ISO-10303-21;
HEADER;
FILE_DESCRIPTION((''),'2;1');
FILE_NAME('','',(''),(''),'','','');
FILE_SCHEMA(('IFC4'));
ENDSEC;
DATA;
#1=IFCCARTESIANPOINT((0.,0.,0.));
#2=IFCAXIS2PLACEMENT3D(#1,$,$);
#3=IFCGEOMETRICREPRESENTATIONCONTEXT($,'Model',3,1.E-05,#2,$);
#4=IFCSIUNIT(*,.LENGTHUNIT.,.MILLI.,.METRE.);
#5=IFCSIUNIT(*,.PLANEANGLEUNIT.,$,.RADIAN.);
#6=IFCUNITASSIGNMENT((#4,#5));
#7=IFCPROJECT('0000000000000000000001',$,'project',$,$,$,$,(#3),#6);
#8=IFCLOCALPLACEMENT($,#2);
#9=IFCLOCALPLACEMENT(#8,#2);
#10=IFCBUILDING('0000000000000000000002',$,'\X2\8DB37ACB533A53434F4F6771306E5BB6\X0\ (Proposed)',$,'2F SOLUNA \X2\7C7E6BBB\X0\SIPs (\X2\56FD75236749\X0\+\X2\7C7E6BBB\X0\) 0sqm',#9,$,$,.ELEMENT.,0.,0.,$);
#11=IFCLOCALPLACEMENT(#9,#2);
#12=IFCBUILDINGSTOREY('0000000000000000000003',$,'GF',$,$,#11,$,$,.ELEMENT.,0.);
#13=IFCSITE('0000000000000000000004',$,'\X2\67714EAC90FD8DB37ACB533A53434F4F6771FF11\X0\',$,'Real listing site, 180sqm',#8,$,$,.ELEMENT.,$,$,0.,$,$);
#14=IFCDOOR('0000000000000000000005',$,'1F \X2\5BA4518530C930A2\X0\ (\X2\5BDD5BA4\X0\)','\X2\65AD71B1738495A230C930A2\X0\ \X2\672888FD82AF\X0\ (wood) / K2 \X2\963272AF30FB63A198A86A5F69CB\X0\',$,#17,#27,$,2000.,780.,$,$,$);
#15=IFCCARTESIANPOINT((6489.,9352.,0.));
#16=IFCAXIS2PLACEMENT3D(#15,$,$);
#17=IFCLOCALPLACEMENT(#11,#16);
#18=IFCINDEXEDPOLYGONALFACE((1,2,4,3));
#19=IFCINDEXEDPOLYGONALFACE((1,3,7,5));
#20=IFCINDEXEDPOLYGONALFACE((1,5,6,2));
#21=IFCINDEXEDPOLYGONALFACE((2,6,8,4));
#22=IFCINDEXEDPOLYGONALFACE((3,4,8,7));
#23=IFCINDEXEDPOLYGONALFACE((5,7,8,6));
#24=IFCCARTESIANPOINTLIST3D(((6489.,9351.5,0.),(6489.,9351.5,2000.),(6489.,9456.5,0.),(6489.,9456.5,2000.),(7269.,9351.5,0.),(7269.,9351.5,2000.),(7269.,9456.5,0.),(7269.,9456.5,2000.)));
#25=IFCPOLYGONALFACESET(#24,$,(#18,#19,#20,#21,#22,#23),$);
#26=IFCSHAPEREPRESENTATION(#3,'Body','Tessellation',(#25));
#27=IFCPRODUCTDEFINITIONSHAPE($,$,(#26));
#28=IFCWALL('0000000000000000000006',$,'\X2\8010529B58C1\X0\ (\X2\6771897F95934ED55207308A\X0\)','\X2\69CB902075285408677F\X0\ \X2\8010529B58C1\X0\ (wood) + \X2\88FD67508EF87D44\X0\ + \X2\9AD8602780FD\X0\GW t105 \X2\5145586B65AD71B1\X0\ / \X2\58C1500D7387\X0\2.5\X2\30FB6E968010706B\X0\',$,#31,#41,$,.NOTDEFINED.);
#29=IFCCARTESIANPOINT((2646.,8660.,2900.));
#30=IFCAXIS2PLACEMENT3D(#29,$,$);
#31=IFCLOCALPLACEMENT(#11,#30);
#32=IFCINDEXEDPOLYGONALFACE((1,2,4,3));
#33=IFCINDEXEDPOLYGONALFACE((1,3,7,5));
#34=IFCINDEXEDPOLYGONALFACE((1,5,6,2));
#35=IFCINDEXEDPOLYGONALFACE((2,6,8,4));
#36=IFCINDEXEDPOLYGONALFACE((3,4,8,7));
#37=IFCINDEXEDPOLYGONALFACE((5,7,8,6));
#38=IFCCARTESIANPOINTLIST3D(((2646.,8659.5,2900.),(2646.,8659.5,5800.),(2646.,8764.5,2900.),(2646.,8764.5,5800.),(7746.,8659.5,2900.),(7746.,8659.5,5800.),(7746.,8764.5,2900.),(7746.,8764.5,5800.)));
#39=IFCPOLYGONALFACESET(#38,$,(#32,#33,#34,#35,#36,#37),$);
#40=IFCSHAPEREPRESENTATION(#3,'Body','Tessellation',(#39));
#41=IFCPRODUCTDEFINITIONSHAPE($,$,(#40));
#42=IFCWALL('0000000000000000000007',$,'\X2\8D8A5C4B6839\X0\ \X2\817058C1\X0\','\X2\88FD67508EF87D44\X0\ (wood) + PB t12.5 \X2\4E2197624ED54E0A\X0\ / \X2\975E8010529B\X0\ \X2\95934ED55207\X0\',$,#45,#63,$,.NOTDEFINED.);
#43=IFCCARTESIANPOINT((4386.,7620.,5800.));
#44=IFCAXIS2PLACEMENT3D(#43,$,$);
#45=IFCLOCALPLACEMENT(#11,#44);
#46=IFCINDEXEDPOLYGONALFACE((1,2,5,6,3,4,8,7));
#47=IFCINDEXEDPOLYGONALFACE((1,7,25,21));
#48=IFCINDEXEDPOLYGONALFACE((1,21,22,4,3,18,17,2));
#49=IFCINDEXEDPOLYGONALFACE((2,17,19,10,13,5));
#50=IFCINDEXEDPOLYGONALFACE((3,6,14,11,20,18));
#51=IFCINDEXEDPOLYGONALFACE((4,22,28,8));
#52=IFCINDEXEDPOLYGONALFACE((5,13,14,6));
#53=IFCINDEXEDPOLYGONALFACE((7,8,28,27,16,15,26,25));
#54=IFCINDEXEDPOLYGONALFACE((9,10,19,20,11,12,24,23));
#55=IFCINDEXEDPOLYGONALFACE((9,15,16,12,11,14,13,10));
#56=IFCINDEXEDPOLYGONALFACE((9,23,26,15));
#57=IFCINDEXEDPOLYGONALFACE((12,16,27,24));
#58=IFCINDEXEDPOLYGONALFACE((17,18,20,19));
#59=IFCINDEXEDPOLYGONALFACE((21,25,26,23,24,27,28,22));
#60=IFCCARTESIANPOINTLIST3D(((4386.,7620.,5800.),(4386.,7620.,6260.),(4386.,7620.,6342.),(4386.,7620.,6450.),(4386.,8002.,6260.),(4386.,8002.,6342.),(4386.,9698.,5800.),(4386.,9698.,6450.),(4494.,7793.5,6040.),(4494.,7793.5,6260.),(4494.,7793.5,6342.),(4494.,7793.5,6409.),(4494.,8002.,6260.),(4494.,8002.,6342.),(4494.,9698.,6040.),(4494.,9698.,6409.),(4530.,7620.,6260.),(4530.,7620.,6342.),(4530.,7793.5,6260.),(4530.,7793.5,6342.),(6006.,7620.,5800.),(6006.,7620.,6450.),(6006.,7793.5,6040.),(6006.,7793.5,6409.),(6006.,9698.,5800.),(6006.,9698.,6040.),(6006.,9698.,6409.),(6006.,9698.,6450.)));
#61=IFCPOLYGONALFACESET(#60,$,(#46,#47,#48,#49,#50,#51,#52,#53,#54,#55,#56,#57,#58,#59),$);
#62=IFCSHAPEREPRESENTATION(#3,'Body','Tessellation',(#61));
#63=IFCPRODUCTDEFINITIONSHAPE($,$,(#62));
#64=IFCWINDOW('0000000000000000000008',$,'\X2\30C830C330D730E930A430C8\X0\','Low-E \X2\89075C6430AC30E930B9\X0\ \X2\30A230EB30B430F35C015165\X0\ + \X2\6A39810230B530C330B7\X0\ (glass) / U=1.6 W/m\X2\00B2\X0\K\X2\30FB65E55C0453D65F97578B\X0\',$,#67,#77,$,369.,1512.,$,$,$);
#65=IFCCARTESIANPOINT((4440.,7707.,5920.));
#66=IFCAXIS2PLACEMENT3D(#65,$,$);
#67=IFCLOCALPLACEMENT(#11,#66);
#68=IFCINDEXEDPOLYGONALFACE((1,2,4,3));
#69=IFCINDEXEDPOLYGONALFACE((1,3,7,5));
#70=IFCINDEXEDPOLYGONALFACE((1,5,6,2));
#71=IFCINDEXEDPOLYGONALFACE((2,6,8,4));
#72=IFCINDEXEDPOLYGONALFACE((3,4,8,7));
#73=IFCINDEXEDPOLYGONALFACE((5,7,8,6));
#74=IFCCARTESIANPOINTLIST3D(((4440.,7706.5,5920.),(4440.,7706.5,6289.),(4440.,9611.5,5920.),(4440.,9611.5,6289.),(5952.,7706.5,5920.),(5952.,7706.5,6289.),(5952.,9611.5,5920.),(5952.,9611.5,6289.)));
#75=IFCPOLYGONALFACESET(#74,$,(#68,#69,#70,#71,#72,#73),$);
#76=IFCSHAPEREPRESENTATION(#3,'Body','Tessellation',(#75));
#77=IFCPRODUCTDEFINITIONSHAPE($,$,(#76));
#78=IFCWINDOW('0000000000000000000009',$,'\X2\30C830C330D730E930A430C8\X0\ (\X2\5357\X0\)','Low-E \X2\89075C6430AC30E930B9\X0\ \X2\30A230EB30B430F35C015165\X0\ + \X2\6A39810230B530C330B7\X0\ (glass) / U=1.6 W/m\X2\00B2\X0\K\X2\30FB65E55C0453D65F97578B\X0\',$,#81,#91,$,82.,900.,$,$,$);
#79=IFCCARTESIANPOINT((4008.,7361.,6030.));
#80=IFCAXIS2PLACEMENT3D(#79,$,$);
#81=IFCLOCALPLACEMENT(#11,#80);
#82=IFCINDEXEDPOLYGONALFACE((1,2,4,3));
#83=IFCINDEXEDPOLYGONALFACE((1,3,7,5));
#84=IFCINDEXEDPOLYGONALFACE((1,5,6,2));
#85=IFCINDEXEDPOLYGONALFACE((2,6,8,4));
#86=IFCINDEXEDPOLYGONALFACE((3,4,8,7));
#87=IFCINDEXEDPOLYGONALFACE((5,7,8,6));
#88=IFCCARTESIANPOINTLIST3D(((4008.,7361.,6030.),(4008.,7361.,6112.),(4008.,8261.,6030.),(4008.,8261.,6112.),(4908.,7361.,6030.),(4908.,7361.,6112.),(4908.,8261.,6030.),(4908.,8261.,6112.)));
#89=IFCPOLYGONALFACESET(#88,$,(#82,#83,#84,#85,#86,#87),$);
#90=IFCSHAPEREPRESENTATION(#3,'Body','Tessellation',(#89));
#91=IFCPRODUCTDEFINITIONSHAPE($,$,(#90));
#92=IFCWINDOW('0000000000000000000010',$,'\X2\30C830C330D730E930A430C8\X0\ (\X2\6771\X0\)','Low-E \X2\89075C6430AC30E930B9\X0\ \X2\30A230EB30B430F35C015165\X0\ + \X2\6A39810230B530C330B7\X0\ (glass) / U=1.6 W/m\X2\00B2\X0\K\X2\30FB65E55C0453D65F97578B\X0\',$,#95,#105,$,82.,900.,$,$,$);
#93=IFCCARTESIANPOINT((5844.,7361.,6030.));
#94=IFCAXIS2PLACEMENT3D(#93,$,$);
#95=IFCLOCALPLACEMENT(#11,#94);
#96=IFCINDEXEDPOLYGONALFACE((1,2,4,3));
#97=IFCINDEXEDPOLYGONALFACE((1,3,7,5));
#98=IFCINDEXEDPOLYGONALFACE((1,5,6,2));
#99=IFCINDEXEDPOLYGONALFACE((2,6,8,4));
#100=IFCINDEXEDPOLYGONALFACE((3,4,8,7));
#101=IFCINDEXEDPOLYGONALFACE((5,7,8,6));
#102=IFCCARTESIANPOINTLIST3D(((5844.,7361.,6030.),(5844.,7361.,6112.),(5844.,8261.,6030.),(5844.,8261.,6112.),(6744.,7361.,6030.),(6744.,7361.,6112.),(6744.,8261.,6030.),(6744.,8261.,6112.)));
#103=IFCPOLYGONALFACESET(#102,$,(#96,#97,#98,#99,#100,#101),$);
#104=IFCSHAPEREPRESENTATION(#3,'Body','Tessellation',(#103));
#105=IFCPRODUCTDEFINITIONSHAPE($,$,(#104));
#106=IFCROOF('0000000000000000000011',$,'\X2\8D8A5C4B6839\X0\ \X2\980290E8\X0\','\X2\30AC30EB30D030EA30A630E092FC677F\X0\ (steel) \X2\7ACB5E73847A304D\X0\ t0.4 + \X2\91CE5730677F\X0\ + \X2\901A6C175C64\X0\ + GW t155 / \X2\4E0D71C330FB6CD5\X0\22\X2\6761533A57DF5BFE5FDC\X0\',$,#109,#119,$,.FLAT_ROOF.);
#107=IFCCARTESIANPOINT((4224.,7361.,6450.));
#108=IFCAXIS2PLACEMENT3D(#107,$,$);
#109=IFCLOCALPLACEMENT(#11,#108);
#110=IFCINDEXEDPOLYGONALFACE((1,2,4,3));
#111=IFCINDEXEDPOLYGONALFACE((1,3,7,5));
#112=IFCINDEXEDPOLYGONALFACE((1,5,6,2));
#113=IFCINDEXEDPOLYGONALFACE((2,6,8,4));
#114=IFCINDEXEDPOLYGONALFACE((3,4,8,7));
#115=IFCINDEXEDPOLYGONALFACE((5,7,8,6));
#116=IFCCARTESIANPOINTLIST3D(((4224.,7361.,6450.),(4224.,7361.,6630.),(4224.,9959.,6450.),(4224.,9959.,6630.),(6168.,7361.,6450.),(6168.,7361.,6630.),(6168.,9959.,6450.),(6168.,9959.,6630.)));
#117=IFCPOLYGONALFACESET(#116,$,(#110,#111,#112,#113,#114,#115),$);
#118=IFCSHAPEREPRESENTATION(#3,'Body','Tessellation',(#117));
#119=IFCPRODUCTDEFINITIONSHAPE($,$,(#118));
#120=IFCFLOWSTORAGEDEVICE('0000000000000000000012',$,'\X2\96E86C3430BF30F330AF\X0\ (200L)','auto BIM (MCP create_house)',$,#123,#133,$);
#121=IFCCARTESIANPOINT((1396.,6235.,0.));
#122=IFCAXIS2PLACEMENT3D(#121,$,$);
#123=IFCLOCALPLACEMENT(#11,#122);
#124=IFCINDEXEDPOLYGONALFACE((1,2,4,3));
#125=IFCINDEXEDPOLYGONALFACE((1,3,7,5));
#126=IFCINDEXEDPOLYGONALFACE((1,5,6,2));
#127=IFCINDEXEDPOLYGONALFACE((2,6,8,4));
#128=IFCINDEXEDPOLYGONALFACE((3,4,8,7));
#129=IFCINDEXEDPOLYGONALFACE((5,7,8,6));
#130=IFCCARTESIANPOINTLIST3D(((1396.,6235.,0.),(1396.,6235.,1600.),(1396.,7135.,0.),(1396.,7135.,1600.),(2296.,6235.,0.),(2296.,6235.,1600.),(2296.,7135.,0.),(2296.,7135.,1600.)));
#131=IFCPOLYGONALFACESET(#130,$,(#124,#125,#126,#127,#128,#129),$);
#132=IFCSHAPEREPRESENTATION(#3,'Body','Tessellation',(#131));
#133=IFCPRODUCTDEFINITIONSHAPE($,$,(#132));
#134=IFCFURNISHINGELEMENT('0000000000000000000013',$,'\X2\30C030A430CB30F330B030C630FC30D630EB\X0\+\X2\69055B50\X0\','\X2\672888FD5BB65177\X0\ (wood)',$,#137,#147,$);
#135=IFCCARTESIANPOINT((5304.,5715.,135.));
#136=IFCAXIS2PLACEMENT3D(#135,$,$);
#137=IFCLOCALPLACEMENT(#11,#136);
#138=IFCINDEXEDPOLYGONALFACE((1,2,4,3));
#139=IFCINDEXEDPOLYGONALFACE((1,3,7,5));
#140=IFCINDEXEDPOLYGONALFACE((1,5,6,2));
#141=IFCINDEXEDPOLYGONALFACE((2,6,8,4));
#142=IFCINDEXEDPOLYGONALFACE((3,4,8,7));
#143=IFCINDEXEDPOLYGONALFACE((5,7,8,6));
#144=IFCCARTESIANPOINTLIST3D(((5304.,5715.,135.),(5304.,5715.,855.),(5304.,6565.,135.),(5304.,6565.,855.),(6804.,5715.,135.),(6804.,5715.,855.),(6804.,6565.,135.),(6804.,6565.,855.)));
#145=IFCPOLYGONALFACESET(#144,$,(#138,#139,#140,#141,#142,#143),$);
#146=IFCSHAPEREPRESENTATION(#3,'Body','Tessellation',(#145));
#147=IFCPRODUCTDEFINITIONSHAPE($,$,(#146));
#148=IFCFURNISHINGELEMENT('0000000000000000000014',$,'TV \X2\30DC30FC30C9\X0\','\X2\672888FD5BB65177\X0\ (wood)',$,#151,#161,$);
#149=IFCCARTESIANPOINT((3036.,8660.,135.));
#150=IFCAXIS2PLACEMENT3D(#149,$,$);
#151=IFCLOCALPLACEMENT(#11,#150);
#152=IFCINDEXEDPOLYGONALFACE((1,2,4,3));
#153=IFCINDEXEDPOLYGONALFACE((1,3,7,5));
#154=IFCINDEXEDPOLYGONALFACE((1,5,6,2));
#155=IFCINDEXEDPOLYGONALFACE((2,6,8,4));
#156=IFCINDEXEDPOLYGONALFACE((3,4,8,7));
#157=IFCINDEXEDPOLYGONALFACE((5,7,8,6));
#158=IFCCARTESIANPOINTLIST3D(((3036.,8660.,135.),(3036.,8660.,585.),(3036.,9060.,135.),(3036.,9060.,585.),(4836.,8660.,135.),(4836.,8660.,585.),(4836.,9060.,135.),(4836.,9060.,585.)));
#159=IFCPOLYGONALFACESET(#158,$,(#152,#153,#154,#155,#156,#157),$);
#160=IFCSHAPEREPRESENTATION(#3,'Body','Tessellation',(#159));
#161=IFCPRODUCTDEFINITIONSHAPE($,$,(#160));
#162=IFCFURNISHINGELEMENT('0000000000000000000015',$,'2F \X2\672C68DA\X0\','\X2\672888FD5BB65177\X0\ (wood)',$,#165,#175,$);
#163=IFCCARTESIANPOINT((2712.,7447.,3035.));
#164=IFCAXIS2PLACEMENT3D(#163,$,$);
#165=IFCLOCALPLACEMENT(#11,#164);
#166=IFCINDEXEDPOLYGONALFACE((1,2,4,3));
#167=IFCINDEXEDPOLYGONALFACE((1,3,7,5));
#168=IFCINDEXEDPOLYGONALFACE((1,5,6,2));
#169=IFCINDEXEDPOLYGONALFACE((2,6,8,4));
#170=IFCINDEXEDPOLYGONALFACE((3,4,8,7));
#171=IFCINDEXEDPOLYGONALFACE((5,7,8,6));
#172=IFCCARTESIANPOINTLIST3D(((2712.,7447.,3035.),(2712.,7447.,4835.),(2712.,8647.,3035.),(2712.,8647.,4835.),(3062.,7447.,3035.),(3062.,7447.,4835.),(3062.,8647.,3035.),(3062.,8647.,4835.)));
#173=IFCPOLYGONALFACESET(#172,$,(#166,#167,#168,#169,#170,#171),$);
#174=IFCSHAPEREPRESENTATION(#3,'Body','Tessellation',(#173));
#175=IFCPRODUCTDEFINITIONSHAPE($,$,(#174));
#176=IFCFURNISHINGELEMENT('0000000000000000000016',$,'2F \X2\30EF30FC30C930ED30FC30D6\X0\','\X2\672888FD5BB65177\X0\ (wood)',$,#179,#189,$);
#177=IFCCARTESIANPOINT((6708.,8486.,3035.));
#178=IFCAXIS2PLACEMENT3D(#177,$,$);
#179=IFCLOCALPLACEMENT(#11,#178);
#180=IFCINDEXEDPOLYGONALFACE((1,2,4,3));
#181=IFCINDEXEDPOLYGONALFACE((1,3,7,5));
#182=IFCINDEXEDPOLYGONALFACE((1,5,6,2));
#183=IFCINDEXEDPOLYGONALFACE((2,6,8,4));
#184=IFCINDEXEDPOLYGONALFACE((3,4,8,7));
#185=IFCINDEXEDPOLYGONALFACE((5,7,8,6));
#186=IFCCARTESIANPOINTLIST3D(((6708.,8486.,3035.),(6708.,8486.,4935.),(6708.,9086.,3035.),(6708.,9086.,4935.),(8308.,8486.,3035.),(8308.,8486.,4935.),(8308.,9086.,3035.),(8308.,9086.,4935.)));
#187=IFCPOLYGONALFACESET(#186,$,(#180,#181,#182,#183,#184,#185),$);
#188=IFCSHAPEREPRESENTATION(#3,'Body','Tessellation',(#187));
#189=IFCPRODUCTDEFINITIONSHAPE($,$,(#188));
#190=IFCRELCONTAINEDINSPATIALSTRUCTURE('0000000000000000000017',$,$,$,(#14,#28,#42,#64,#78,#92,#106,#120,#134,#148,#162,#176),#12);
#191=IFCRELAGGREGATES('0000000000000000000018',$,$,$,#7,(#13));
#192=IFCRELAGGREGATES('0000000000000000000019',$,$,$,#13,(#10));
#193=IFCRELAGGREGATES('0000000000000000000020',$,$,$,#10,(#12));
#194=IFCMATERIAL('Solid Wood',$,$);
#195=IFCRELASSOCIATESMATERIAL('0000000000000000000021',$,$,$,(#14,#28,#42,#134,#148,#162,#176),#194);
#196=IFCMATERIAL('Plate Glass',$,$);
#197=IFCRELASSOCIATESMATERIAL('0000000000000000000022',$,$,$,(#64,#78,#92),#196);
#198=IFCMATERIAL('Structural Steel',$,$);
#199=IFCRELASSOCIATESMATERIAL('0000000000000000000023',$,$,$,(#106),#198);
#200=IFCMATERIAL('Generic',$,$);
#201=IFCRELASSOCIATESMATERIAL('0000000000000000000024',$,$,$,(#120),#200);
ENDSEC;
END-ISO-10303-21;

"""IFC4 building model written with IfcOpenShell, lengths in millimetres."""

from ifc_helpers import new_model, si_unit, frame, frame_2d, origin, place, context, project, spatial, rectangle, extrude, material, element, fill, save


model = new_model("IFC4")

# Units and contexts
model_context = context("Model", 3, precision=1e-05, world=origin())
ifc_project = project(units=[si_unit("LENGTHUNIT", "METRE", prefix="MILLI"), si_unit("PLANEANGLEUNIT", "RADIAN")], contexts=[model_context])

# Site, building, storey
site_placement = place(None, origin())
site = spatial("IfcSite", under=ifc_project, at=site_placement, Name="東京都足立区千住東１", ObjectType="Real listing site, 180sqm", CompositionType="ELEMENT", RefElevation=0.0)
building_placement = place(site_placement, origin())
building = spatial("IfcBuilding", under=site, at=building_placement, Name="足立区千住東の家 (Proposed)", ObjectType="2F SOLUNA 籾殻SIPs (国産杉+籾殻) 0sqm", CompositionType="ELEMENT", ElevationOfRefHeight=0.0, ElevationOfTerrain=0.0)
storey_placement = place(building_placement, origin())
storey = spatial("IfcBuildingStorey", under=building, at=storey_placement, Name="GF", CompositionType="ELEMENT", Elevation=0.0)

# Shared definitions
ifc_material_1 = material(Name="Solid Wood")

# Door
door_placement = place(storey_placement, frame((6489.0, 9352.0, 0.0)))
element("IfcDoor", 1, at=door_placement, inside=storey, material=ifc_material_1, Name="1F 室内ドア (寝室)", Description="断熱玄関ドア 木製芯 (wood) / K2 防犯・採風機構", OverallHeight=2000.0, OverallWidth=780.0, context=model_context, shape_type="SweptSolid", body=[
    extrude(rectangle(XDim=780.0, YDim=105.0, at=frame_2d((390.0, 52.0))), frame((6489.0, 9352.0, 0.0)), (0.0, 0.0, 1.0), 2000.0),
])

# Wall
wall_1_placement = place(storey_placement, frame((2646.0, 8660.0, 2900.0)))
element("IfcWall", 2, at=wall_1_placement, inside=storey, material=ifc_material_1, Name="耐力壁 (東西間仕切り)", Description="構造用合板 耐力壁 (wood) + 製材軸組 + 高性能GW t105 充填断熱 / 壁倍率2.5・準耐火", PredefinedType="NOTDEFINED", context=model_context, shape_type="SweptSolid", body=[
    extrude(rectangle(XDim=5100.0, YDim=105.0, at=frame_2d((2550.0, 52.0))), frame((2646.0, 8660.0, 2900.0)), (0.0, 0.0, 1.0), 2900.0),
])

# Wall, openings, windows
wall_2_placement = place(storey_placement, frame((4386.0, 7620.0, 5800.0)))
wall_2 = element("IfcWall", 3, at=wall_2_placement, inside=storey, material=ifc_material_1, Name="越屋根 腰壁", Description="製材軸組 (wood) + PB t12.5 両面仕上 / 非耐力 間仕切", PredefinedType="NOTDEFINED", context=model_context, shape_type="SweptSolid", body=[
    extrude(rectangle(XDim=1620.0, YDim=2078.0, at=frame_2d((810.0, 1039.0))), frame((4386.0, 7620.0, 5800.0)), (0.0, 0.0, 1.0), 650.0),
])
opening_1_placement = place(storey_placement, frame((4440.0, 7707.0, 5920.0)))
opening_1 = element("IfcOpeningElement", 4, at=opening_1_placement, cuts=wall_2, PredefinedType="NOTDEFINED", context=model_context, shape_type="SweptSolid", body=[
    extrude(rectangle(XDim=1512.0, YDim=1905.0, at=frame_2d((756.0, 952.0))), frame((4440.0, 7707.0, 5920.0)), (0.0, 0.0, 1.0), 369.0),
])
opening_2_placement = place(storey_placement, frame((4008.0, 7361.0, 6030.0)))
opening_2 = element("IfcOpeningElement", 5, at=opening_2_placement, cuts=wall_2, PredefinedType="NOTDEFINED", context=model_context, shape_type="SweptSolid", body=[
    extrude(rectangle(XDim=900.0, YDim=900.0, at=frame_2d((450.0, 450.0))), frame((4008.0, 7361.0, 6030.0)), (0.0, 0.0, 1.0), 82.0),
])
opening_3_placement = place(storey_placement, frame((5844.0, 7361.0, 6030.0)))
opening_3 = element("IfcOpeningElement", 6, at=opening_3_placement, cuts=wall_2, PredefinedType="NOTDEFINED", context=model_context, shape_type="SweptSolid", body=[
    extrude(rectangle(XDim=900.0, YDim=900.0, at=frame_2d((450.0, 450.0))), frame((5844.0, 7361.0, 6030.0)), (0.0, 0.0, 1.0), 82.0),
])
ifc_material_2 = material(Name="Plate Glass")
window_1_placement = place(storey_placement, frame((4440.0, 7707.0, 5920.0)))
window_1 = element("IfcWindow", 7, at=window_1_placement, inside=storey, material=ifc_material_2, Name="トップライト", Description="Low-E 複層ガラス アルゴン封入 + 樹脂サッシ (glass) / U=1.6 W/m²K・日射取得型", OverallHeight=369.0, OverallWidth=1512.0, context=model_context, shape_type="SweptSolid", body=[
    extrude(rectangle(XDim=1512.0, YDim=1905.0, at=frame_2d((756.0, 952.0))), frame((4440.0, 7707.0, 5920.0)), (0.0, 0.0, 1.0), 369.0),
])
fill(opening_1, window_1)
window_2_placement = place(storey_placement, frame((4008.0, 7361.0, 6030.0)))
window_2 = element("IfcWindow", 8, at=window_2_placement, inside=storey, material=ifc_material_2, Name="トップライト (南)", Description="Low-E 複層ガラス アルゴン封入 + 樹脂サッシ (glass) / U=1.6 W/m²K・日射取得型", OverallHeight=82.0, OverallWidth=900.0, context=model_context, shape_type="SweptSolid", body=[
    extrude(rectangle(XDim=900.0, YDim=900.0, at=frame_2d((450.0, 450.0))), frame((4008.0, 7361.0, 6030.0)), (0.0, 0.0, 1.0), 82.0),
])
fill(opening_2, window_2)
window_3_placement = place(storey_placement, frame((5844.0, 7361.0, 6030.0)))
window_3 = element("IfcWindow", 9, at=window_3_placement, inside=storey, material=ifc_material_2, Name="トップライト (東)", Description="Low-E 複層ガラス アルゴン封入 + 樹脂サッシ (glass) / U=1.6 W/m²K・日射取得型", OverallHeight=82.0, OverallWidth=900.0, context=model_context, shape_type="SweptSolid", body=[
    extrude(rectangle(XDim=900.0, YDim=900.0, at=frame_2d((450.0, 450.0))), frame((5844.0, 7361.0, 6030.0)), (0.0, 0.0, 1.0), 82.0),
])
fill(opening_3, window_3)

# Roof
ifc_material_3 = material(Name="Structural Steel")
roof_placement = place(storey_placement, frame((4224.0, 7361.0, 6450.0)))
element("IfcRoof", 10, at=roof_placement, inside=storey, material=ifc_material_3, Name="越屋根 頂部", Description="ガルバリウム鋼板 (steel) 立平葺き t0.4 + 野地板 + 通気層 + GW t155 / 不燃・法22条区域対応", PredefinedType="FLAT_ROOF", context=model_context, shape_type="SweptSolid", body=[
    extrude(rectangle(XDim=1944.0, YDim=2598.0, at=frame_2d((972.0, 1299.0))), frame((4224.0, 7361.0, 6450.0)), (0.0, 0.0, 1.0), 180.0),
])

# Flow storage device
ifc_material_4 = material(Name="Generic")
flow_storage_device_placement = place(storey_placement, frame((1396.0, 6235.0, 0.0)))
element("IfcFlowStorageDevice", 11, at=flow_storage_device_placement, inside=storey, material=ifc_material_4, Name="雨水タンク (200L)", Description="auto BIM (MCP create_house)", context=model_context, shape_type="SweptSolid", body=[
    extrude(rectangle(XDim=900.0, YDim=900.0, at=frame_2d((450.0, 450.0))), frame((1396.0, 6235.0, 0.0)), (0.0, 0.0, 1.0), 1600.0),
])

# Furnishing elements
furnishing_1_placement = place(storey_placement, frame((5304.0, 5715.0, 135.0)))
element("IfcFurnishingElement", 12, at=furnishing_1_placement, inside=storey, material=ifc_material_1, Name="ダイニングテーブル+椅子", Description="木製家具 (wood)", context=model_context, shape_type="SweptSolid", body=[
    extrude(rectangle(XDim=1500.0, YDim=850.0, at=frame_2d((750.0, 425.0))), frame((5304.0, 5715.0, 135.0)), (0.0, 0.0, 1.0), 720.0),
])
furnishing_2_placement = place(storey_placement, frame((3036.0, 8660.0, 135.0)))
element("IfcFurnishingElement", 13, at=furnishing_2_placement, inside=storey, material=ifc_material_1, Name="TV ボード", Description="木製家具 (wood)", context=model_context, shape_type="SweptSolid", body=[
    extrude(rectangle(XDim=1800.0, YDim=400.0, at=frame_2d((900.0, 200.0))), frame((3036.0, 8660.0, 135.0)), (0.0, 0.0, 1.0), 450.0),
])
furnishing_3_placement = place(storey_placement, frame((2712.0, 7447.0, 3035.0)))
element("IfcFurnishingElement", 14, at=furnishing_3_placement, inside=storey, material=ifc_material_1, Name="2F 本棚", Description="木製家具 (wood)", context=model_context, shape_type="SweptSolid", body=[
    extrude(rectangle(XDim=350.0, YDim=1200.0, at=frame_2d((175.0, 600.0))), frame((2712.0, 7447.0, 3035.0)), (0.0, 0.0, 1.0), 1800.0),
])
furnishing_4_placement = place(storey_placement, frame((6708.0, 8486.0, 3035.0)))
element("IfcFurnishingElement", 15, at=furnishing_4_placement, inside=storey, material=ifc_material_1, Name="2F ワードローブ", Description="木製家具 (wood)", context=model_context, shape_type="SweptSolid", body=[
    extrude(rectangle(XDim=1600.0, YDim=600.0, at=frame_2d((800.0, 300.0))), frame((6708.0, 8486.0, 3035.0)), (0.0, 0.0, 1.0), 1900.0),
])

save(model, "model.ifc")
